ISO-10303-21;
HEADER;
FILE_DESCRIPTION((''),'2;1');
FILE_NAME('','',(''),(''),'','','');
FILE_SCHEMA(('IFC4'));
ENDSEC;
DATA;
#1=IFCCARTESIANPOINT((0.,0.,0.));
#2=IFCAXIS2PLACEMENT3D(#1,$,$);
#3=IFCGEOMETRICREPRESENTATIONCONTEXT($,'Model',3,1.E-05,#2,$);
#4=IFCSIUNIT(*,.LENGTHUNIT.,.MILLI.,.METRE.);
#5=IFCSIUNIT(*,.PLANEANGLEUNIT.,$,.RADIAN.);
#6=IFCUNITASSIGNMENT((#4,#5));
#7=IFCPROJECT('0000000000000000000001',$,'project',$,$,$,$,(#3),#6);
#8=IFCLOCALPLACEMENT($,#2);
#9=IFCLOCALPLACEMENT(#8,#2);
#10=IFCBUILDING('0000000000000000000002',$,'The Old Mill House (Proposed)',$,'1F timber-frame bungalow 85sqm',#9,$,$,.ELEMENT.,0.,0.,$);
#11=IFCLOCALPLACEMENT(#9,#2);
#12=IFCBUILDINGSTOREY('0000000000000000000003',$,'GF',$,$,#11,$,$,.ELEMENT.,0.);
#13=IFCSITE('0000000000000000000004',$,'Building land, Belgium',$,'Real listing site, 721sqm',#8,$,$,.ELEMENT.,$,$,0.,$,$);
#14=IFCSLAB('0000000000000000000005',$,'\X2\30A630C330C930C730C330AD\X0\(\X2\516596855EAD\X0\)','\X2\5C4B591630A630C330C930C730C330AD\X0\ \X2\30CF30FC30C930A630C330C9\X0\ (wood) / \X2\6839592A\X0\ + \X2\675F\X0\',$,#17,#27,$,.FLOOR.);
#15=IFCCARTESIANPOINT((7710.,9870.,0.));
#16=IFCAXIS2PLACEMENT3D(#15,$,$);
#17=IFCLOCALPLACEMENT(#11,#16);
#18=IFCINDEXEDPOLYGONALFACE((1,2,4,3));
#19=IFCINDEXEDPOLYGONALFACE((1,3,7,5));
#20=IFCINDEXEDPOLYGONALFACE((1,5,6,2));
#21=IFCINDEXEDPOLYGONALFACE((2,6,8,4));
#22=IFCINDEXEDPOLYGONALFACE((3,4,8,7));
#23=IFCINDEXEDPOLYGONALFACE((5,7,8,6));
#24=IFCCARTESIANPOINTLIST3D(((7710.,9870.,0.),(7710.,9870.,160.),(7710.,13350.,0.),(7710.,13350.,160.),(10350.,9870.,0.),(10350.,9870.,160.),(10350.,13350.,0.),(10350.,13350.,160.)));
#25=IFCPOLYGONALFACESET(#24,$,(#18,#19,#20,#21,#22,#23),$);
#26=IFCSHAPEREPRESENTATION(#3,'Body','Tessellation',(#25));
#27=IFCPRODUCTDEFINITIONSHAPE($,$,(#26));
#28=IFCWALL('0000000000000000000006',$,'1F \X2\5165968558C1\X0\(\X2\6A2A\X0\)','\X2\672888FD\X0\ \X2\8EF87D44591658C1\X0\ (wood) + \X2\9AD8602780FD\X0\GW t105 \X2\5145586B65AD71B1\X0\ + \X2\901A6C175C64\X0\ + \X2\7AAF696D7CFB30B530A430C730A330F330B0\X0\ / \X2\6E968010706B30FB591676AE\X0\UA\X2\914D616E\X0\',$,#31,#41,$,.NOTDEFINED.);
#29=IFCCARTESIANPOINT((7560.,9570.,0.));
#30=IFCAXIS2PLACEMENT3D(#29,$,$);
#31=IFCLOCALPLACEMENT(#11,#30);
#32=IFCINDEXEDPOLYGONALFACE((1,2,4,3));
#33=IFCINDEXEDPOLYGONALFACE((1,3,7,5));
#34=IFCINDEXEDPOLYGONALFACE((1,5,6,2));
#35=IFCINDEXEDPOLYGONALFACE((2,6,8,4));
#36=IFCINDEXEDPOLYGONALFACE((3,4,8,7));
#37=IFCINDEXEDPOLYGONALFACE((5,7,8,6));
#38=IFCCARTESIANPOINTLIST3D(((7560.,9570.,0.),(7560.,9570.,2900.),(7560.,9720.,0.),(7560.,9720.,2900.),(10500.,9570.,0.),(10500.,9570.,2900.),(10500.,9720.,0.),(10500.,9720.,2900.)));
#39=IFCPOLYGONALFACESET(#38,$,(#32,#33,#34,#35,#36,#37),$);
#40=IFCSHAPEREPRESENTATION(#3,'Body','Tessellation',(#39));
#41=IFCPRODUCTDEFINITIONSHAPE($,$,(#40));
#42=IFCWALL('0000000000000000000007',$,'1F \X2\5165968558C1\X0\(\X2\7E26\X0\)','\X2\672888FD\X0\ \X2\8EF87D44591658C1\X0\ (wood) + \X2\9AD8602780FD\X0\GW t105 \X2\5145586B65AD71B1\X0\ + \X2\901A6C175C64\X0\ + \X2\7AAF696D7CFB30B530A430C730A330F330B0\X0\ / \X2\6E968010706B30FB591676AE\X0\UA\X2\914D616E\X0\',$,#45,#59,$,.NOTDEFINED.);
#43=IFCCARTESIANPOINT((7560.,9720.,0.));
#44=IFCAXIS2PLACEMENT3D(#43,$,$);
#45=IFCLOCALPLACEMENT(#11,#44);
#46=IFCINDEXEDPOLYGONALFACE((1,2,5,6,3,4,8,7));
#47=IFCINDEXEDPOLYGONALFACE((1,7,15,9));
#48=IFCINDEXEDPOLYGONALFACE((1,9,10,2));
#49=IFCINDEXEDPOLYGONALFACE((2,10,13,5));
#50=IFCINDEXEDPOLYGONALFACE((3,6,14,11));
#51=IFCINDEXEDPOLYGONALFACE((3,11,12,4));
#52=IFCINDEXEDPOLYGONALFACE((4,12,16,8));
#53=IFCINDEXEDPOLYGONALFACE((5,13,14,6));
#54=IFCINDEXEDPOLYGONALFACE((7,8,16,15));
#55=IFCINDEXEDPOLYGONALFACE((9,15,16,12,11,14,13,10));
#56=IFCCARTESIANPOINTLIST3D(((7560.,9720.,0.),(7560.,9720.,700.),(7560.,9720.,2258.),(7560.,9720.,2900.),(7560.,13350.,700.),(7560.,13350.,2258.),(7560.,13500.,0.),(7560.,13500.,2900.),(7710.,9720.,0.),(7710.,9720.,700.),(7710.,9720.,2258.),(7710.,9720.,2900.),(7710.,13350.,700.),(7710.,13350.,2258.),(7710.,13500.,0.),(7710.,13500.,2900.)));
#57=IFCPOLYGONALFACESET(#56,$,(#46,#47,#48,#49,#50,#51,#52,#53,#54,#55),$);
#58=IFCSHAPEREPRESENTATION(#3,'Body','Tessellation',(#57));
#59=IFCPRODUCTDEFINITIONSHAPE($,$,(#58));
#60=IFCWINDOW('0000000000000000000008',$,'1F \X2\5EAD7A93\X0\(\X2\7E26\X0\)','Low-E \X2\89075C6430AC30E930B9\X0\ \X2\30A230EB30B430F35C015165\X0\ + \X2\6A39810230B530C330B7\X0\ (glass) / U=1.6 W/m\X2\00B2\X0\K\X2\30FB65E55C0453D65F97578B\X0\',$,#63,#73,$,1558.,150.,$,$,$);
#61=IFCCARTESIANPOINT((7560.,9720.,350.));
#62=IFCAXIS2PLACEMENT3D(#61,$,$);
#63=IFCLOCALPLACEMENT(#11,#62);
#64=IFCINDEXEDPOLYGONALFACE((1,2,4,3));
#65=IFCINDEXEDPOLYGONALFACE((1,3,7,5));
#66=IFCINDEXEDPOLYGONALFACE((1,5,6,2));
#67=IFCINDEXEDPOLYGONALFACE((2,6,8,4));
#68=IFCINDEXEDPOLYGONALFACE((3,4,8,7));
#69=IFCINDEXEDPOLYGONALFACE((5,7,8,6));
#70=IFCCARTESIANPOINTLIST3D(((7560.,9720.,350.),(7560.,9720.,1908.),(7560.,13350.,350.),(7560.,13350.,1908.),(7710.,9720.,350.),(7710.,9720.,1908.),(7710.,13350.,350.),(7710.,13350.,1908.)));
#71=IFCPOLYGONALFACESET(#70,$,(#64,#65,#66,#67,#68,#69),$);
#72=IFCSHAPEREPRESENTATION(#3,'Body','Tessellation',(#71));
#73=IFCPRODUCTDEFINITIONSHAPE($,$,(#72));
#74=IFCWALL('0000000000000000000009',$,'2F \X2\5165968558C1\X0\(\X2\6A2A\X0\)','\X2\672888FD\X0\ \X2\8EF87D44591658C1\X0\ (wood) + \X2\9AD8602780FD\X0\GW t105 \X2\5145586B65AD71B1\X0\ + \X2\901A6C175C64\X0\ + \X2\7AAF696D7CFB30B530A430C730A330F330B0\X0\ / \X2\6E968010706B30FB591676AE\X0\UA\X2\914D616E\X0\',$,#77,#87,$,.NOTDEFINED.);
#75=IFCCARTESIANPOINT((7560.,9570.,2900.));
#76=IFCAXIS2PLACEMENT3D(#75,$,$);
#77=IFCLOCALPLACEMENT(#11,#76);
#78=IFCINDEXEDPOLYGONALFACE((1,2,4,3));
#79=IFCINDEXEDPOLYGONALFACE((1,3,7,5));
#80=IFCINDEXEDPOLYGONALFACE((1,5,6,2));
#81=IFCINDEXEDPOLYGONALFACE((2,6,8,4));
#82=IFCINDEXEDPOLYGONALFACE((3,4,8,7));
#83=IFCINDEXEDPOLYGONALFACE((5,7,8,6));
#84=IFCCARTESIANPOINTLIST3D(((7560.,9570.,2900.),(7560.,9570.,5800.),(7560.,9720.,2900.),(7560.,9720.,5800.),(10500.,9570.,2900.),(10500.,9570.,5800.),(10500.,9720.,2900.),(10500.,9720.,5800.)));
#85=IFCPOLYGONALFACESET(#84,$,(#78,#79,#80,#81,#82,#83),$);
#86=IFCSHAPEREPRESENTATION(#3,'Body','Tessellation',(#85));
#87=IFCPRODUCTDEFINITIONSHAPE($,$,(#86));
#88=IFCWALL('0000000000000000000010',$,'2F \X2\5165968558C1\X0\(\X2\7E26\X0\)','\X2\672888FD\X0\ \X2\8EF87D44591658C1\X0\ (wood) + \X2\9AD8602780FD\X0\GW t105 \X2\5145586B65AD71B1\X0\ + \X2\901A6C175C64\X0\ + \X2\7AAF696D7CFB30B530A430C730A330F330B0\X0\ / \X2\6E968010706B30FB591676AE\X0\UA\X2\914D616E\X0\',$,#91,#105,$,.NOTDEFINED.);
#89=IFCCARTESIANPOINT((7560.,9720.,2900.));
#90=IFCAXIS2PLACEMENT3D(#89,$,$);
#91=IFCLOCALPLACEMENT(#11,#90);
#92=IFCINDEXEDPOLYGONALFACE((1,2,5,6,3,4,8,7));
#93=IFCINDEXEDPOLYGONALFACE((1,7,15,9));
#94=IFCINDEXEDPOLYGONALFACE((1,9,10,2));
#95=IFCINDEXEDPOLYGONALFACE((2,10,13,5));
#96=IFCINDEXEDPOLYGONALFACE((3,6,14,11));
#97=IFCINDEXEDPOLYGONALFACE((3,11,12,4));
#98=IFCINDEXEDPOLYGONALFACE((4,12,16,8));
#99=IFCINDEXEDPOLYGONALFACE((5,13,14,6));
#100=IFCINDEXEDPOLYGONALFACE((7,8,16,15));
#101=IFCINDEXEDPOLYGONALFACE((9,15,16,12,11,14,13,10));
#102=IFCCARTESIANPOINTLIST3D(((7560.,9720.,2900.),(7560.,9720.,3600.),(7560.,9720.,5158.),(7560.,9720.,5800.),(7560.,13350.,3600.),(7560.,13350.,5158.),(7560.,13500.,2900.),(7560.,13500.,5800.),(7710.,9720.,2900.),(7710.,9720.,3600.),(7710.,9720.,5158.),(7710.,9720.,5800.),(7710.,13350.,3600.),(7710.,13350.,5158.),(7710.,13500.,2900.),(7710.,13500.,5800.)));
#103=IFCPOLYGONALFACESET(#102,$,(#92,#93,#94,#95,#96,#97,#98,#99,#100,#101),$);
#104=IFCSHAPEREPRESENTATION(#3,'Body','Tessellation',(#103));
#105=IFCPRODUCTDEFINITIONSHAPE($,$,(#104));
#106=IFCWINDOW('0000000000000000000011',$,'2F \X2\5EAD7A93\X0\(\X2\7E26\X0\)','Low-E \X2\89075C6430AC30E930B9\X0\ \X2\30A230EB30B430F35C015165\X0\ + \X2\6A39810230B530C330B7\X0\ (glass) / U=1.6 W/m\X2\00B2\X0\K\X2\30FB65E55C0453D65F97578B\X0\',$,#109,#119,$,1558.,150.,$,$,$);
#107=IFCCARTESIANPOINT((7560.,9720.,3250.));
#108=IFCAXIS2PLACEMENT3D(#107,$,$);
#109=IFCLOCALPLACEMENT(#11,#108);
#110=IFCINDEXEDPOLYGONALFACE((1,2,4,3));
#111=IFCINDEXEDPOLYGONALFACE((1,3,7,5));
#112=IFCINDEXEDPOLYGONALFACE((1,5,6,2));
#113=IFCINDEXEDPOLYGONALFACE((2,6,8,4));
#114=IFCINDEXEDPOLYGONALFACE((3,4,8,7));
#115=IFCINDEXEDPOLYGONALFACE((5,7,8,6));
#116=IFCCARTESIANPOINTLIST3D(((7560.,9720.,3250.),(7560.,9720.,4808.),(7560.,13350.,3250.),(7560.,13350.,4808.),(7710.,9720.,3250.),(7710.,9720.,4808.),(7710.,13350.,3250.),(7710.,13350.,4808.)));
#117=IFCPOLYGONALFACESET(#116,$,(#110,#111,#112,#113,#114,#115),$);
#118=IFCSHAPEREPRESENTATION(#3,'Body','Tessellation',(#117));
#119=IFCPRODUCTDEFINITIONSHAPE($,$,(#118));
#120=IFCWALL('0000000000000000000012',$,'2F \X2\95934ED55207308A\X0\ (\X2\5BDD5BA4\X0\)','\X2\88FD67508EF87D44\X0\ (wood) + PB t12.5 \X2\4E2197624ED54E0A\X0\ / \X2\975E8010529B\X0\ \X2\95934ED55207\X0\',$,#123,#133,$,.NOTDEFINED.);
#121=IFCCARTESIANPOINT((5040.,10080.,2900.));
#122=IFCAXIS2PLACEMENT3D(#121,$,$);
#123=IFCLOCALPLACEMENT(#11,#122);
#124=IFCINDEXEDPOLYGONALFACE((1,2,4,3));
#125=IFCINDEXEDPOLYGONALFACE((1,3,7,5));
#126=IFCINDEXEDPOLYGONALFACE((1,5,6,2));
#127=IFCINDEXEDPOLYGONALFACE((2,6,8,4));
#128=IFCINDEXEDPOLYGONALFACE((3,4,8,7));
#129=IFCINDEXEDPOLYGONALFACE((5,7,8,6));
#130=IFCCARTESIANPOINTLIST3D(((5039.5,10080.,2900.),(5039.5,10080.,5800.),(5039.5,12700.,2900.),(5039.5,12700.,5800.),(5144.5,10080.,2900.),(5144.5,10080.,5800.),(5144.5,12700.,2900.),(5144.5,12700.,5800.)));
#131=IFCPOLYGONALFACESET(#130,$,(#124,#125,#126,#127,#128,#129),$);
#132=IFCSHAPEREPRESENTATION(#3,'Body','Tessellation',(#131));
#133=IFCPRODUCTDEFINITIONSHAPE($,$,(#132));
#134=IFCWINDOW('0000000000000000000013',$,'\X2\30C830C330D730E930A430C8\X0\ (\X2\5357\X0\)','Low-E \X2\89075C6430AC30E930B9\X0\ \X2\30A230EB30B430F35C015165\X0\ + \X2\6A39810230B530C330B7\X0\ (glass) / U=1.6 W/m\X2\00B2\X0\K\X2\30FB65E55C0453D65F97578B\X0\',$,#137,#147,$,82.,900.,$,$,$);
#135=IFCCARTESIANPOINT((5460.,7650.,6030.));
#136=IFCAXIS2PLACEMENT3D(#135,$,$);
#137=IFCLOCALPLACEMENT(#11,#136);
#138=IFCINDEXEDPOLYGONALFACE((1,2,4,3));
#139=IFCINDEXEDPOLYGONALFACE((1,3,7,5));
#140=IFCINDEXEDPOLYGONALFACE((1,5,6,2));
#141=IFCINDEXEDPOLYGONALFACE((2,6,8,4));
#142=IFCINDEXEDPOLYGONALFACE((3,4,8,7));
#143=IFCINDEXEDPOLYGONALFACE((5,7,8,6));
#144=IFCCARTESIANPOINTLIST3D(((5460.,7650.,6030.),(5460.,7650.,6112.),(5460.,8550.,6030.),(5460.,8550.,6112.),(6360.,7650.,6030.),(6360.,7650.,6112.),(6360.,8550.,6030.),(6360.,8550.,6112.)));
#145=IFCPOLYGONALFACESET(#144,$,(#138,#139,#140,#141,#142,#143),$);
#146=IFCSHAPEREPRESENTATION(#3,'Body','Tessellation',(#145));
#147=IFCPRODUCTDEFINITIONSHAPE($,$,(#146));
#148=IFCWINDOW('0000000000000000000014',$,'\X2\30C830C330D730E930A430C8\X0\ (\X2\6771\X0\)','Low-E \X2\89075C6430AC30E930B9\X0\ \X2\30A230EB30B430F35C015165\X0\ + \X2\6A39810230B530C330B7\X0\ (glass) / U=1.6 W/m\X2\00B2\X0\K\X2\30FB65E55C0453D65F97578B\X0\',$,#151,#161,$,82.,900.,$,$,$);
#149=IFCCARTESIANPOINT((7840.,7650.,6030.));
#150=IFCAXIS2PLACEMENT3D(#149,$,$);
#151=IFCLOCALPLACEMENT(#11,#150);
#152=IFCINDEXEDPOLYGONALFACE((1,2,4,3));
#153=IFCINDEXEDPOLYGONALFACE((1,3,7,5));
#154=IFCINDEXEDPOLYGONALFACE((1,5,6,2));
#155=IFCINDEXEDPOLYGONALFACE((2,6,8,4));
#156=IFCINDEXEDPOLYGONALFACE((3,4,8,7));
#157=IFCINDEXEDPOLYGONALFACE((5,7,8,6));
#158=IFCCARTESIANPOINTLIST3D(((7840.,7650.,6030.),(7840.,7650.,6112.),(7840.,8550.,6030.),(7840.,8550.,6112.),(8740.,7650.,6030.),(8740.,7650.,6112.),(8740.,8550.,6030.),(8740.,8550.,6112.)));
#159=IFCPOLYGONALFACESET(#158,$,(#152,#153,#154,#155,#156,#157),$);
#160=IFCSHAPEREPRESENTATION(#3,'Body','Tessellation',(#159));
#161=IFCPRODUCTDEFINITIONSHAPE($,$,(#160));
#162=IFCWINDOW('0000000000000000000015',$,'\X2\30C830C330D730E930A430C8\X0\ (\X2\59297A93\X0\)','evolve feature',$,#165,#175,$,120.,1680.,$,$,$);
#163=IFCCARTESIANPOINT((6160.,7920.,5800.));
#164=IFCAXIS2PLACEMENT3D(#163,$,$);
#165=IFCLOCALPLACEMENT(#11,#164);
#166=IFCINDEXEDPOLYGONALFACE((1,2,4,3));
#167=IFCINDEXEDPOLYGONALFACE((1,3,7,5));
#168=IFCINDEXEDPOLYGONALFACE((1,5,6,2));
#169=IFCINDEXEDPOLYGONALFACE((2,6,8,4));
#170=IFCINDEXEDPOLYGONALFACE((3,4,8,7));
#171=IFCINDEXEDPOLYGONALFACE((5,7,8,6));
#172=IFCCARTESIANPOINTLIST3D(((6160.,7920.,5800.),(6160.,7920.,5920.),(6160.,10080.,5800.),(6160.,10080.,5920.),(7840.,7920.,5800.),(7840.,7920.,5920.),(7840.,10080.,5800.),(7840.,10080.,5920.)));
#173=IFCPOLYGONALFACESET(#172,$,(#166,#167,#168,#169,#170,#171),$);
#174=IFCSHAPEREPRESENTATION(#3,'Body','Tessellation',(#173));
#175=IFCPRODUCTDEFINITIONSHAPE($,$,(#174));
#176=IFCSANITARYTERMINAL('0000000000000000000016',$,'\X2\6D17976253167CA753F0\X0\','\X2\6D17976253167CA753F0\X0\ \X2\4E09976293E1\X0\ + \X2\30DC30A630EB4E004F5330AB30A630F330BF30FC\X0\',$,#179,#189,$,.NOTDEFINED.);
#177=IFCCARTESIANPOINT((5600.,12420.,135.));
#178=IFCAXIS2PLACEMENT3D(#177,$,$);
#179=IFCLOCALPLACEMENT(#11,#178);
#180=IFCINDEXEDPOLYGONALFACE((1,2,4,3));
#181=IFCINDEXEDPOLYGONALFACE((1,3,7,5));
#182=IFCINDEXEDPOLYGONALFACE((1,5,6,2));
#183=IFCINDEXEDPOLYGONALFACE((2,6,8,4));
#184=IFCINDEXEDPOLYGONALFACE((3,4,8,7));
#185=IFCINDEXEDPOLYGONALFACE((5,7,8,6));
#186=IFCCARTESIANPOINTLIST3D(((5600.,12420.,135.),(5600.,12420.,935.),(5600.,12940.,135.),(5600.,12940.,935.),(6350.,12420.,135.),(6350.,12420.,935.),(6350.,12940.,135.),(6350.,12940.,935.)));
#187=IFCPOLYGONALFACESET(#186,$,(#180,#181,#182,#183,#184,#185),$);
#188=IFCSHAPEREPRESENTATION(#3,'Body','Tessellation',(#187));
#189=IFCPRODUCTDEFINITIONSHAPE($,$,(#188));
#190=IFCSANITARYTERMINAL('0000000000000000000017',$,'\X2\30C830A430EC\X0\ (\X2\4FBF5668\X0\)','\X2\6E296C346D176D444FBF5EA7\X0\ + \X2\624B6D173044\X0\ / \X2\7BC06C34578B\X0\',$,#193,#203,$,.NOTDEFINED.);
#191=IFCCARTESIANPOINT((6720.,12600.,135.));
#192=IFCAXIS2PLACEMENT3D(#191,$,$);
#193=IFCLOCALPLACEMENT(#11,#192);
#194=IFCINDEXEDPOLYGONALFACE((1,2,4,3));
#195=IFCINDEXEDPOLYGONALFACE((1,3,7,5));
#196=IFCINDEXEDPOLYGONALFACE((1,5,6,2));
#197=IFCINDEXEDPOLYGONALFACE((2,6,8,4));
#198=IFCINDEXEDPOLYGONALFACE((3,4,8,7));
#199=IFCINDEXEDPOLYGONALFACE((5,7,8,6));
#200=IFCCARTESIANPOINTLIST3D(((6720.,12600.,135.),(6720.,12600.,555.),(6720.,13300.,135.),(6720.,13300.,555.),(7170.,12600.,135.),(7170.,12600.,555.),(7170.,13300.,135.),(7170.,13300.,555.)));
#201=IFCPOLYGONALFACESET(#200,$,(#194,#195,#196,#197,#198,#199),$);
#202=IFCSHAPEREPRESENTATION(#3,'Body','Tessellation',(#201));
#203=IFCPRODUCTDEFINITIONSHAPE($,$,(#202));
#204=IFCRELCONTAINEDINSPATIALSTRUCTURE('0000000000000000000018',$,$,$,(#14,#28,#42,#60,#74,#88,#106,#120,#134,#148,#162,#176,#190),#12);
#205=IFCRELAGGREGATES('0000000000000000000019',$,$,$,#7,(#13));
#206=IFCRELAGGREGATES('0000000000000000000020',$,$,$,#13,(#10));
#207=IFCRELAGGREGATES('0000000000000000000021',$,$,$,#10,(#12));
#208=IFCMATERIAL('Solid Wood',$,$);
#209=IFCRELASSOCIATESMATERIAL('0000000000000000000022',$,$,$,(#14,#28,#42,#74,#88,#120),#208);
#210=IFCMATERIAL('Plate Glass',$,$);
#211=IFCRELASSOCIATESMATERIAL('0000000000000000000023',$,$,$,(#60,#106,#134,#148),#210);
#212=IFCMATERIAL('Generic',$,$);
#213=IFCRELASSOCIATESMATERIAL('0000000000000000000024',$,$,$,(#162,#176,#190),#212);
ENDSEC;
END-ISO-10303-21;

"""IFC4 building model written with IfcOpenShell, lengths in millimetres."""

from ifc_helpers import new_model, si_unit, frame, frame_2d, origin, place, context, project, spatial, rectangle, extrude, material, element, fill, save


model = new_model("IFC4")

# Units and contexts
model_context = context("Model", 3, precision=1e-05, world=origin())
ifc_project = project(units=[si_unit("LENGTHUNIT", "METRE", prefix="MILLI"), si_unit("PLANEANGLEUNIT", "RADIAN")], contexts=[model_context])

# Site, building, storey
site_placement = place(None, origin())
site = spatial("IfcSite", under=ifc_project, at=site_placement, Name="Building land, Belgium", ObjectType="Real listing site, 721sqm", CompositionType="ELEMENT", RefElevation=0.0)
building_placement = place(site_placement, origin())
building = spatial("IfcBuilding", under=site, at=building_placement, Name="The Old Mill House (Proposed)", ObjectType="1F timber-frame bungalow 85sqm", CompositionType="ELEMENT", ElevationOfRefHeight=0.0, ElevationOfTerrain=0.0)
storey_placement = place(building_placement, origin())
storey = spatial("IfcBuildingStorey", under=building, at=storey_placement, Name="GF", CompositionType="ELEMENT", Elevation=0.0)

# Slab
ifc_material_1 = material(Name="Solid Wood")
slab_placement = place(storey_placement, frame((7710.0, 9870.0, 0.0)))
element("IfcSlab", 1, at=slab_placement, inside=storey, material=ifc_material_1, Name="ウッドデッキ(入隅庭)", Description="屋外ウッドデッキ ハードウッド (wood) / 根太 + 束", PredefinedType="FLOOR", context=model_context, shape_type="SweptSolid", body=[
    extrude(rectangle(XDim=2640.0, YDim=3480.0, at=frame_2d((1320.0, 1740.0))), frame((7710.0, 9870.0, 0.0)), (0.0, 0.0, 1.0), 160.0),
])

# Wall
wall_1_placement = place(storey_placement, frame((7560.0, 9570.0, 0.0)))
element("IfcWall", 2, at=wall_1_placement, inside=storey, material=ifc_material_1, Name="1F 入隅壁(横)", Description="木製 軸組外壁 (wood) + 高性能GW t105 充填断熱 + 通気層 + 窯業系サイディング / 準耐火・外皮UA配慮", PredefinedType="NOTDEFINED", context=model_context, shape_type="SweptSolid", body=[
    extrude(rectangle(XDim=2940.0, YDim=150.0, at=frame_2d((1470.0, 75.0))), frame((7560.0, 9570.0, 0.0)), (0.0, 0.0, 1.0), 2900.0),
])

# Wall, opening, window
wall_2_placement = place(storey_placement, frame((7560.0, 9720.0, 0.0)))
wall_2 = element("IfcWall", 3, at=wall_2_placement, inside=storey, material=ifc_material_1, Name="1F 入隅壁(縦)", Description="木製 軸組外壁 (wood) + 高性能GW t105 充填断熱 + 通気層 + 窯業系サイディング / 準耐火・外皮UA配慮", PredefinedType="NOTDEFINED", context=model_context, shape_type="SweptSolid", body=[
    extrude(rectangle(XDim=150.0, YDim=3780.0, at=frame_2d((75.0, 1890.0))), frame((7560.0, 9720.0, 0.0)), (0.0, 0.0, 1.0), 2900.0),
])
opening_1_placement = place(storey_placement, frame((7560.0, 9720.0, 350.0)))
opening_1 = element("IfcOpeningElement", 4, at=opening_1_placement, cuts=wall_2, PredefinedType="NOTDEFINED", context=model_context, shape_type="SweptSolid", body=[
    extrude(rectangle(XDim=150.0, YDim=3630.0, at=frame_2d((75.0, 1815.0))), frame((7560.0, 9720.0, 350.0)), (0.0, 0.0, 1.0), 1558.0),
])
ifc_material_2 = material(Name="Plate Glass")
window_1_placement = place(storey_placement, frame((7560.0, 9720.0, 350.0)))
window_1 = element("IfcWindow", 5, at=window_1_placement, inside=storey, material=ifc_material_2, Name="1F 庭窓(縦)", Description="Low-E 複層ガラス アルゴン封入 + 樹脂サッシ (glass) / U=1.6 W/m²K・日射取得型", OverallHeight=1558.0, OverallWidth=150.0, context=model_context, shape_type="SweptSolid", body=[
    extrude(rectangle(XDim=150.0, YDim=3630.0, at=frame_2d((75.0, 1815.0))), frame((7560.0, 9720.0, 350.0)), (0.0, 0.0, 1.0), 1558.0),
])
fill(opening_1, window_1)

# Wall
wall_3_placement = place(storey_placement, frame((7560.0, 9570.0, 2900.0)))
element("IfcWall", 6, at=wall_3_placement, inside=storey, material=ifc_material_1, Name="2F 入隅壁(横)", Description="木製 軸組外壁 (wood) + 高性能GW t105 充填断熱 + 通気層 + 窯業系サイディング / 準耐火・外皮UA配慮", PredefinedType="NOTDEFINED", context=model_context, shape_type="SweptSolid", body=[
    extrude(rectangle(XDim=2940.0, YDim=150.0, at=frame_2d((1470.0, 75.0))), frame((7560.0, 9570.0, 2900.0)), (0.0, 0.0, 1.0), 2900.0),
])

# Wall, opening, window
wall_4_placement = place(storey_placement, frame((7560.0, 9720.0, 2900.0)))
wall_4 = element("IfcWall", 7, at=wall_4_placement, inside=storey, material=ifc_material_1, Name="2F 入隅壁(縦)", Description="木製 軸組外壁 (wood) + 高性能GW t105 充填断熱 + 通気層 + 窯業系サイディング / 準耐火・外皮UA配慮", PredefinedType="NOTDEFINED", context=model_context, shape_type="SweptSolid", body=[
    extrude(rectangle(XDim=150.0, YDim=3780.0, at=frame_2d((75.0, 1890.0))), frame((7560.0, 9720.0, 2900.0)), (0.0, 0.0, 1.0), 2900.0),
])
opening_2_placement = place(storey_placement, frame((7560.0, 9720.0, 3250.0)))
opening_2 = element("IfcOpeningElement", 8, at=opening_2_placement, cuts=wall_4, PredefinedType="NOTDEFINED", context=model_context, shape_type="SweptSolid", body=[
    extrude(rectangle(XDim=150.0, YDim=3630.0, at=frame_2d((75.0, 1815.0))), frame((7560.0, 9720.0, 3250.0)), (0.0, 0.0, 1.0), 1558.0),
])
window_2_placement = place(storey_placement, frame((7560.0, 9720.0, 3250.0)))
window_2 = element("IfcWindow", 9, at=window_2_placement, inside=storey, material=ifc_material_2, Name="2F 庭窓(縦)", Description="Low-E 複層ガラス アルゴン封入 + 樹脂サッシ (glass) / U=1.6 W/m²K・日射取得型", OverallHeight=1558.0, OverallWidth=150.0, context=model_context, shape_type="SweptSolid", body=[
    extrude(rectangle(XDim=150.0, YDim=3630.0, at=frame_2d((75.0, 1815.0))), frame((7560.0, 9720.0, 3250.0)), (0.0, 0.0, 1.0), 1558.0),
])
fill(opening_2, window_2)

# Wall
wall_5_placement = place(storey_placement, frame((5040.0, 10080.0, 2900.0)))
element("IfcWall", 10, at=wall_5_placement, inside=storey, material=ifc_material_1, Name="2F 間仕切り (寝室)", Description="製材軸組 (wood) + PB t12.5 両面仕上 / 非耐力 間仕切", PredefinedType="NOTDEFINED", context=model_context, shape_type="SweptSolid", body=[
    extrude(rectangle(XDim=105.0, YDim=2620.0, at=frame_2d((52.0, 1310.0))), frame((5040.0, 10080.0, 2900.0)), (0.0, 0.0, 1.0), 2900.0),
])

# Windows
window_3_placement = place(storey_placement, frame((5460.0, 7650.0, 6030.0)))
element("IfcWindow", 11, at=window_3_placement, inside=storey, material=ifc_material_2, Name="トップライト (南)", Description="Low-E 複層ガラス アルゴン封入 + 樹脂サッシ (glass) / U=1.6 W/m²K・日射取得型", OverallHeight=82.0, OverallWidth=900.0, context=model_context, shape_type="SweptSolid", body=[
    extrude(rectangle(XDim=900.0, YDim=900.0, at=frame_2d((450.0, 450.0))), frame((5460.0, 7650.0, 6030.0)), (0.0, 0.0, 1.0), 82.0),
])
window_4_placement = place(storey_placement, frame((7840.0, 7650.0, 6030.0)))
element("IfcWindow", 12, at=window_4_placement, inside=storey, material=ifc_material_2, Name="トップライト (東)", Description="Low-E 複層ガラス アルゴン封入 + 樹脂サッシ (glass) / U=1.6 W/m²K・日射取得型", OverallHeight=82.0, OverallWidth=900.0, context=model_context, shape_type="SweptSolid", body=[
    extrude(rectangle(XDim=900.0, YDim=900.0, at=frame_2d((450.0, 450.0))), frame((7840.0, 7650.0, 6030.0)), (0.0, 0.0, 1.0), 82.0),
])
ifc_material_3 = material(Name="Generic")
window_5_placement = place(storey_placement, frame((6160.0, 7920.0, 5800.0)))
element("IfcWindow", 13, at=window_5_placement, inside=storey, material=ifc_material_3, Name="トップライト (天窓)", Description="evolve feature", OverallHeight=120.0, OverallWidth=1680.0, context=model_context, shape_type="SweptSolid", body=[
    extrude(rectangle(XDim=1680.0, YDim=2160.0, at=frame_2d((840.0, 1080.0))), frame((6160.0, 7920.0, 5800.0)), (0.0, 0.0, 1.0), 120.0),
])

# Sanitary terminals
sanitary_terminal_1_placement = place(storey_placement, frame((5600.0, 12420.0, 135.0)))
element("IfcSanitaryTerminal", 14, at=sanitary_terminal_1_placement, inside=storey, material=ifc_material_3, Name="洗面化粧台", Description="洗面化粧台 三面鏡 + ボウル一体カウンター", PredefinedType="NOTDEFINED", context=model_context, shape_type="SweptSolid", body=[
    extrude(rectangle(XDim=750.0, YDim=520.0, at=frame_2d((375.0, 260.0))), frame((5600.0, 12420.0, 135.0)), (0.0, 0.0, 1.0), 800.0),
])
sanitary_terminal_2_placement = place(storey_placement, frame((6720.0, 12600.0, 135.0)))
element("IfcSanitaryTerminal", 15, at=sanitary_terminal_2_placement, inside=storey, material=ifc_material_3, Name="トイレ (便器)", Description="温水洗浄便座 + 手洗い / 節水型", PredefinedType="NOTDEFINED", context=model_context, shape_type="SweptSolid", body=[
    extrude(rectangle(XDim=450.0, YDim=700.0, at=frame_2d((225.0, 350.0))), frame((6720.0, 12600.0, 135.0)), (0.0, 0.0, 1.0), 420.0),
])

save(model, "model.ifc")
